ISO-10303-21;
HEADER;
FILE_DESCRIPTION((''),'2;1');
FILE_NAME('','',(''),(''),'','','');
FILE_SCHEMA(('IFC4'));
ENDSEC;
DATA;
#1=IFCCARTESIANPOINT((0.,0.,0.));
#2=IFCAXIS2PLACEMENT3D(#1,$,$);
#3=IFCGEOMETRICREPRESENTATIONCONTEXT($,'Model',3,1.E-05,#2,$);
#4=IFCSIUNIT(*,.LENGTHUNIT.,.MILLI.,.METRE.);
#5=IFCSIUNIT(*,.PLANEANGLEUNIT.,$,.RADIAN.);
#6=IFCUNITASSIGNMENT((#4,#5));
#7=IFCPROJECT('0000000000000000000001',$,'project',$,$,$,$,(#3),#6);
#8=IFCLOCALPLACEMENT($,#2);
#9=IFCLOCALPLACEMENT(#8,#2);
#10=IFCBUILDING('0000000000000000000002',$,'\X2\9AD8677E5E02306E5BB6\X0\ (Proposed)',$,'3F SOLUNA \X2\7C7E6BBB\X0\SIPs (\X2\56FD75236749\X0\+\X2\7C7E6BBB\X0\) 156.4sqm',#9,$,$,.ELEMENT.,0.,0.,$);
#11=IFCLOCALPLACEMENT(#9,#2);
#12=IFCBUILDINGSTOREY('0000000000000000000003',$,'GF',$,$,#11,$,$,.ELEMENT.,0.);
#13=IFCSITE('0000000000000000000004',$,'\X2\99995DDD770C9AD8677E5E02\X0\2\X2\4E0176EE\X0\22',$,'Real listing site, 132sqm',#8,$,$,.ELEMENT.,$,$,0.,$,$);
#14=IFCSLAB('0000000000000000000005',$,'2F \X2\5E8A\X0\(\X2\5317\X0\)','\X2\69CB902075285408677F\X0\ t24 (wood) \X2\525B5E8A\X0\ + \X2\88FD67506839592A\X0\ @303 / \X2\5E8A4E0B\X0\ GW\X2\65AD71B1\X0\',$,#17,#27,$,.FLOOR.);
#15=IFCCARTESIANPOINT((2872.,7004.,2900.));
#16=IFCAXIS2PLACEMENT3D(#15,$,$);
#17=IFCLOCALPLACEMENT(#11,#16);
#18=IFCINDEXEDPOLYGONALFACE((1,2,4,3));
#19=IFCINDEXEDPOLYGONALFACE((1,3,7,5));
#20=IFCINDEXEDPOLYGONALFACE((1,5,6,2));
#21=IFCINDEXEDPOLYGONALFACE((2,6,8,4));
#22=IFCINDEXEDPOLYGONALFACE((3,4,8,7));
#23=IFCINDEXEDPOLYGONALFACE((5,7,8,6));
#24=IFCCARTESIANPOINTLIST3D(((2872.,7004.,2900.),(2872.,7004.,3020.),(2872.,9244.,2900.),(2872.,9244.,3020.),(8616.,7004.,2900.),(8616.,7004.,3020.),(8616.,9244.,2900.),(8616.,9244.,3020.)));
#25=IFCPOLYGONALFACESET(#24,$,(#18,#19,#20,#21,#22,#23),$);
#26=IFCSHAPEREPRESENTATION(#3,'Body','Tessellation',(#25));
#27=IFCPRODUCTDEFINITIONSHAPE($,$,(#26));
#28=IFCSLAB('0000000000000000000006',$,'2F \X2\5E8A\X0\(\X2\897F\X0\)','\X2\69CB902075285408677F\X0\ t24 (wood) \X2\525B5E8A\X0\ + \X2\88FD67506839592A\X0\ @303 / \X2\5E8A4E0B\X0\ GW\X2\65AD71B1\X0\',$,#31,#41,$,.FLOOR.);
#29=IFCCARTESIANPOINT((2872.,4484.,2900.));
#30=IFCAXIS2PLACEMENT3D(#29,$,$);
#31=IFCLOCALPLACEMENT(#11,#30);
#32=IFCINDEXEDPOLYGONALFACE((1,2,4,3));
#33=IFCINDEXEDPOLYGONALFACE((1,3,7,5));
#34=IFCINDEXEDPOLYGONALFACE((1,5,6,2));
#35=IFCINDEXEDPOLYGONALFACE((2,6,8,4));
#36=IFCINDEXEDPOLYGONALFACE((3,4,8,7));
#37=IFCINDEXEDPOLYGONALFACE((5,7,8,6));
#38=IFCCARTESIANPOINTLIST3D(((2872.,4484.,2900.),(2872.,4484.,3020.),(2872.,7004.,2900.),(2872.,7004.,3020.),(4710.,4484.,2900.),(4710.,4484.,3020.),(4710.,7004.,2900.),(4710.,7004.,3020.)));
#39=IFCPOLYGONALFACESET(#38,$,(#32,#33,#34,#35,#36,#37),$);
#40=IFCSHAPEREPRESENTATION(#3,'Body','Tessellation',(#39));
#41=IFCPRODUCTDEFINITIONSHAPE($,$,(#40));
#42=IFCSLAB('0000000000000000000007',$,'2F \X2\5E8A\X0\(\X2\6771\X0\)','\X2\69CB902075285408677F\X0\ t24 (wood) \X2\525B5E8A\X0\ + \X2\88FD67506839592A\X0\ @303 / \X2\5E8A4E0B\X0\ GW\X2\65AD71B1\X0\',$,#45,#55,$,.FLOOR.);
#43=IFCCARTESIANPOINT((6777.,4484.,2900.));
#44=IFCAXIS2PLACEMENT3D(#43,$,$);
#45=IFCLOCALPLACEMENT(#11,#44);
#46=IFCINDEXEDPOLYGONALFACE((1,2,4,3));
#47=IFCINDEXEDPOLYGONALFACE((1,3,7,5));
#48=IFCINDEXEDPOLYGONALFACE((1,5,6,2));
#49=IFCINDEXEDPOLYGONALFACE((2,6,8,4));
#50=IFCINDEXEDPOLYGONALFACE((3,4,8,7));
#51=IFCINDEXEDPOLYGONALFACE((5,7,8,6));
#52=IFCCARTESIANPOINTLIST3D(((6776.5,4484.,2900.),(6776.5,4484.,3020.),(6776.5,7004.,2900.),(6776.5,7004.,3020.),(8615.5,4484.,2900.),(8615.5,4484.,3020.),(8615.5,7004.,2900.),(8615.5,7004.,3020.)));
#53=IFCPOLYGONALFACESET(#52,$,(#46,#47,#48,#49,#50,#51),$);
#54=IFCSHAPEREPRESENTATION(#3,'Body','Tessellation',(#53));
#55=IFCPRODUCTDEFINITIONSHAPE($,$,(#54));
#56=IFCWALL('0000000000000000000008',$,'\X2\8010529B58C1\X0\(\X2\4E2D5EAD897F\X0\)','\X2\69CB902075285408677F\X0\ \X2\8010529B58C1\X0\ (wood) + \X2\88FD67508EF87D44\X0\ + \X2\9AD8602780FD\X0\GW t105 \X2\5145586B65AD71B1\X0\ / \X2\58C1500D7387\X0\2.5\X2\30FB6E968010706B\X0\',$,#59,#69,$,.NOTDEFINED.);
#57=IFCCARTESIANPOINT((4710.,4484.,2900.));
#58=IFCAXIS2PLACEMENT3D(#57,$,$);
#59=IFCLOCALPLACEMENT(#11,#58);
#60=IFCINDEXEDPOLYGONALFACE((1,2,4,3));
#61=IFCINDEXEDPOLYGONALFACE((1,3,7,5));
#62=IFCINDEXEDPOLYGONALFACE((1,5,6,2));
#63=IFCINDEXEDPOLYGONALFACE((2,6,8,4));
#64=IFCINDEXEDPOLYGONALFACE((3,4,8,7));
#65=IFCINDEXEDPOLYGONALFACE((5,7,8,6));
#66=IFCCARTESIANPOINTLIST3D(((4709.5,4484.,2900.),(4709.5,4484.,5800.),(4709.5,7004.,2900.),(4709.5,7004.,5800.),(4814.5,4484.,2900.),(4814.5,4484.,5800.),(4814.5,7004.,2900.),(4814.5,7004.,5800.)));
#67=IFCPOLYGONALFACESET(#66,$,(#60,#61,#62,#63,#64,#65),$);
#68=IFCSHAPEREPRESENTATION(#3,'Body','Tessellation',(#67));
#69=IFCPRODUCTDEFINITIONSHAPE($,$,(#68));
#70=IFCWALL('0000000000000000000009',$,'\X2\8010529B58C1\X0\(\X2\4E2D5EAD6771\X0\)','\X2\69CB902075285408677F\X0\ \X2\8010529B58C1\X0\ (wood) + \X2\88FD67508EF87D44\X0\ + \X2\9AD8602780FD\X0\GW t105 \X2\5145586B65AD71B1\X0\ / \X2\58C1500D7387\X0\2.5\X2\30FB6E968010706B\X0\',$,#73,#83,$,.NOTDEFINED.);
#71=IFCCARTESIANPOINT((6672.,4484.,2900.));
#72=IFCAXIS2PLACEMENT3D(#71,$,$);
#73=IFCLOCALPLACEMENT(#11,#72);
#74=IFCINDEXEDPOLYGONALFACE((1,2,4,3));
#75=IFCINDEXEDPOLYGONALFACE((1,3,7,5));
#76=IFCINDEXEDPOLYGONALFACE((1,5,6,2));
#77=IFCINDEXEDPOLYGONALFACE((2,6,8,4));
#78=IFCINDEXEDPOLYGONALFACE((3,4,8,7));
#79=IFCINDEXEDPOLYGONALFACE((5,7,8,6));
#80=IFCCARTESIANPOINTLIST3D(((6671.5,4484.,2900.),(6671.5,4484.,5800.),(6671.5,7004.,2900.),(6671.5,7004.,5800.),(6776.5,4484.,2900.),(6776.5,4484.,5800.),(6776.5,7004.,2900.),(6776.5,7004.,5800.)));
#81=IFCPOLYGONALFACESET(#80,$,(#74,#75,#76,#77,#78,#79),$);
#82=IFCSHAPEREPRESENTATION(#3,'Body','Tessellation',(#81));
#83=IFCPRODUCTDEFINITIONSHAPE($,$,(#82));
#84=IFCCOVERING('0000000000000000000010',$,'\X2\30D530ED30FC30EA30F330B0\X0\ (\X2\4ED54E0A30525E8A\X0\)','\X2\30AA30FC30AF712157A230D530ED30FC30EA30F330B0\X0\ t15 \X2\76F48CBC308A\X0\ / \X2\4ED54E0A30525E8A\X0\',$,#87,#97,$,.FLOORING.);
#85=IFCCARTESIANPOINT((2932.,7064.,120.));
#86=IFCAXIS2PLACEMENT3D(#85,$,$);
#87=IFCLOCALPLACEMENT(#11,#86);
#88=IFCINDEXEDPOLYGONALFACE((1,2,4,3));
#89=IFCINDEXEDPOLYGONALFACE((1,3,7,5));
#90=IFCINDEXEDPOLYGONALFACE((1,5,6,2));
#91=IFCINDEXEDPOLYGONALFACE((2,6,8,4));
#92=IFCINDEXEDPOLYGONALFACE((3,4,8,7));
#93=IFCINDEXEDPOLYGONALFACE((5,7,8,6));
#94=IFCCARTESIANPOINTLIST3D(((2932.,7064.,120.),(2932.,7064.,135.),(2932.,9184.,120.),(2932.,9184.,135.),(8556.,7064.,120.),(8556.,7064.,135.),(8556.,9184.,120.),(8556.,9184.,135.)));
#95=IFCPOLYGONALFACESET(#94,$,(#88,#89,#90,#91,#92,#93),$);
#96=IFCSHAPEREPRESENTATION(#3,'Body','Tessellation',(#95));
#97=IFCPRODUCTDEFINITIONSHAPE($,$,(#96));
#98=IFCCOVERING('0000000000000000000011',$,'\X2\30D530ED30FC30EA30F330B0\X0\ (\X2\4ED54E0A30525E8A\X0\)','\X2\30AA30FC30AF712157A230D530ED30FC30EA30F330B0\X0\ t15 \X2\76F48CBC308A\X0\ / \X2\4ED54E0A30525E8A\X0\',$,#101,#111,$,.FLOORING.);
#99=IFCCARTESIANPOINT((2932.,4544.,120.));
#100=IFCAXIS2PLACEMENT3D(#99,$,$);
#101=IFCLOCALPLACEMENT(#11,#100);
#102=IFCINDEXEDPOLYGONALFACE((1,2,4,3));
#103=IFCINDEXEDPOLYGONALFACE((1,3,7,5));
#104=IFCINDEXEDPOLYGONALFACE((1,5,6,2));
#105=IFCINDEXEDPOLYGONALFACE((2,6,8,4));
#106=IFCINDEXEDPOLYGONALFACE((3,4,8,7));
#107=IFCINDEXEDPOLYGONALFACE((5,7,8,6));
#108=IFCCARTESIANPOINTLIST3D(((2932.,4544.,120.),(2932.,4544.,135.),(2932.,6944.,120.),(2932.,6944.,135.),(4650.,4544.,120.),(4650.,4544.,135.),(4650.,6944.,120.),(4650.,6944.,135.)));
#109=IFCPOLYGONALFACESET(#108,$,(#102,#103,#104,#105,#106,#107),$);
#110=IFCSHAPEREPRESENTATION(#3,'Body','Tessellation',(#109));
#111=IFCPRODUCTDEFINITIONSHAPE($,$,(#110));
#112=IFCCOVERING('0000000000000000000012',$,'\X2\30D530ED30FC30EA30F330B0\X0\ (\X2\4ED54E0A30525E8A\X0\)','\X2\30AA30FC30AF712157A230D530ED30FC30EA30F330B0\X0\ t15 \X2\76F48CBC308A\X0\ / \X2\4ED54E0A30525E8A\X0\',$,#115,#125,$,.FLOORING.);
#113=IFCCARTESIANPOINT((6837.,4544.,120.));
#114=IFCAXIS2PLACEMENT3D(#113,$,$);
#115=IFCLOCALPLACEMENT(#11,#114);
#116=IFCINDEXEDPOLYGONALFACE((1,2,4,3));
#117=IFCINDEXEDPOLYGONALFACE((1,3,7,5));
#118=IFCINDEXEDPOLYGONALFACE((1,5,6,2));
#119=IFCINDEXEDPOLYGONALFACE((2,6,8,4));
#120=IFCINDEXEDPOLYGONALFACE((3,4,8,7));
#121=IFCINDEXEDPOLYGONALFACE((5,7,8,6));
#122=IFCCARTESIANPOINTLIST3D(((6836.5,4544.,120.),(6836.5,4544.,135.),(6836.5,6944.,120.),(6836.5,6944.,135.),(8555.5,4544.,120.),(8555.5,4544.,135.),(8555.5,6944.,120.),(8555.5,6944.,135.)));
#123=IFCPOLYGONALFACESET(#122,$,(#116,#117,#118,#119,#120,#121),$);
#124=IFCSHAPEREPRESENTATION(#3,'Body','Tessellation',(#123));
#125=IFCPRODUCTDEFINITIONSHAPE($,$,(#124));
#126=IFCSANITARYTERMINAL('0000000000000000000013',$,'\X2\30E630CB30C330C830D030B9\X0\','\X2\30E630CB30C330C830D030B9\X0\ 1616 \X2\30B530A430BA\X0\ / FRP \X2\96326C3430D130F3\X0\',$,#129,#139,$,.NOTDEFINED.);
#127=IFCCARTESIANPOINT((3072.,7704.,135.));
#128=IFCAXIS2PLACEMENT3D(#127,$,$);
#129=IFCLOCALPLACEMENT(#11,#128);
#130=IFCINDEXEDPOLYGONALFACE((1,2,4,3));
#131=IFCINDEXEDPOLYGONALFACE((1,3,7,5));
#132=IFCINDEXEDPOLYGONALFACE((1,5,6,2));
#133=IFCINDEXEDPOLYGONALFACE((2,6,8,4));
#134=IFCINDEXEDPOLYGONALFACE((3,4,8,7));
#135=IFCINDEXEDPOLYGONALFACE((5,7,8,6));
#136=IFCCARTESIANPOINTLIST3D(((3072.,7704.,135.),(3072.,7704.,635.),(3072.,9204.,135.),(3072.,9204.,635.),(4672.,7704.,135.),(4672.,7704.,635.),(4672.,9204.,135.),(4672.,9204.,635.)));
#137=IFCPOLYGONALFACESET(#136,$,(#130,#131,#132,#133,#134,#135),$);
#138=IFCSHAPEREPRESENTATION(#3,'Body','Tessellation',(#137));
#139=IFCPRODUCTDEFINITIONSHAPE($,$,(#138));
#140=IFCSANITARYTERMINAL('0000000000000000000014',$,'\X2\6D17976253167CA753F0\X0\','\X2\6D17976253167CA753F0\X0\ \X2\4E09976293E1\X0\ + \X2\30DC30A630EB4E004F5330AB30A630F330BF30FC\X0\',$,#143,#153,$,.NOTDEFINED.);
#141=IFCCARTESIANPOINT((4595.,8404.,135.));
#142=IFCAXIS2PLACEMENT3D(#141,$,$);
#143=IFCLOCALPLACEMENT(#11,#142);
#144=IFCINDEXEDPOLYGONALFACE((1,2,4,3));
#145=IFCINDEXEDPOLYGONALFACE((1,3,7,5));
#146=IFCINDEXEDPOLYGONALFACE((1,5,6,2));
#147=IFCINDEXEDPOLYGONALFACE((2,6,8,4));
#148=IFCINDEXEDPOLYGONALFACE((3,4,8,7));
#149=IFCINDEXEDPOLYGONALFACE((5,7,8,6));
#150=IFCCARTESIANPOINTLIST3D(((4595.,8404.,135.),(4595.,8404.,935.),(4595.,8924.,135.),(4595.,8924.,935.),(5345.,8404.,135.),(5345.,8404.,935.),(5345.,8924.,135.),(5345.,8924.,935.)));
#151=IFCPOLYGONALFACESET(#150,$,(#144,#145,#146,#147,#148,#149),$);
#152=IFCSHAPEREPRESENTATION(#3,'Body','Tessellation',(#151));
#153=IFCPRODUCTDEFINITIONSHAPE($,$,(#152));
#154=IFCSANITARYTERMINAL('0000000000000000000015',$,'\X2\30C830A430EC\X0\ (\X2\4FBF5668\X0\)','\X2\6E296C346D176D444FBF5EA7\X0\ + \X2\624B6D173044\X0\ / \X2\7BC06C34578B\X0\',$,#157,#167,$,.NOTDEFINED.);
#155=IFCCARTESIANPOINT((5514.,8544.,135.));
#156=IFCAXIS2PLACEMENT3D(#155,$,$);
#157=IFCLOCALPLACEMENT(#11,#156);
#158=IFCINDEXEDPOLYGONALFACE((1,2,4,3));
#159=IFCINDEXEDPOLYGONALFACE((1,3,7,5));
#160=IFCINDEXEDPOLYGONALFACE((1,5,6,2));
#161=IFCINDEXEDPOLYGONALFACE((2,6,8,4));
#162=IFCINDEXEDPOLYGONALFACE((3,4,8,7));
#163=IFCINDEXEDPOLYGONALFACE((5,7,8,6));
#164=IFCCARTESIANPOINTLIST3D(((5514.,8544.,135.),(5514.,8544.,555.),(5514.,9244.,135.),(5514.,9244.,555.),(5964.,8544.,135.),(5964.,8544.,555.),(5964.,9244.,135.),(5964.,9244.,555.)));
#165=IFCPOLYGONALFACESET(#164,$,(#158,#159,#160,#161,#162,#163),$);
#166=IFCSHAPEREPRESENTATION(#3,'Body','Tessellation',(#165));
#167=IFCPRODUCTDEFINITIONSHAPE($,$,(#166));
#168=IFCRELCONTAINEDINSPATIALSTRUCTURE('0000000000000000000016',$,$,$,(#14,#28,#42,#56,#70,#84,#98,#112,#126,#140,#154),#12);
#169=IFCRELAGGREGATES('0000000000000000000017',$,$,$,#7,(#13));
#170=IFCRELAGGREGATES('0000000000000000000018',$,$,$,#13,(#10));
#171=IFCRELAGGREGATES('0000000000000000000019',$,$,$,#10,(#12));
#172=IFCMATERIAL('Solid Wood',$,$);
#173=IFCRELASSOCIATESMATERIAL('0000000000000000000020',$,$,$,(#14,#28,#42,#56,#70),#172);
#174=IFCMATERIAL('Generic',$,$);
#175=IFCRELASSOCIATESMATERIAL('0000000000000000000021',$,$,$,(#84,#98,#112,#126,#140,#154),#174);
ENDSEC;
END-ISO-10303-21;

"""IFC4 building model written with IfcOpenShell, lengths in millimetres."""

from ifc_helpers import new_model, si_unit, frame, frame_2d, origin, place, context, project, spatial, rectangle, extrude, material, element, save


model = new_model("IFC4")

# Units and contexts
model_context = context("Model", 3, precision=1e-05, world=origin())
ifc_project = project(units=[si_unit("LENGTHUNIT", "METRE", prefix="MILLI"), si_unit("PLANEANGLEUNIT", "RADIAN")], contexts=[model_context])

# Site, building, storey
site_placement = place(None, origin())
site = spatial("IfcSite", under=ifc_project, at=site_placement, Name="香川県高松市2丁目22", ObjectType="Real listing site, 132sqm", CompositionType="ELEMENT", RefElevation=0.0)
building_placement = place(site_placement, origin())
building = spatial("IfcBuilding", under=site, at=building_placement, Name="高松市の家 (Proposed)", ObjectType="3F SOLUNA 籾殻SIPs (国産杉+籾殻) 156.4sqm", CompositionType="ELEMENT", ElevationOfRefHeight=0.0, ElevationOfTerrain=0.0)
storey_placement = place(building_placement, origin())
storey = spatial("IfcBuildingStorey", under=building, at=storey_placement, Name="GF", CompositionType="ELEMENT", Elevation=0.0)

# Slabs
ifc_material_1 = material(Name="Solid Wood")
slab_1_placement = place(storey_placement, frame((2872.0, 7004.0, 2900.0)))
element("IfcSlab", 1, at=slab_1_placement, inside=storey, material=ifc_material_1, Name="2F 床(北)", Description="構造用合板 t24 (wood) 剛床 + 製材根太 @303 / 床下 GW断熱", PredefinedType="FLOOR", context=model_context, shape_type="SweptSolid", body=[
    extrude(rectangle(XDim=5744.0, YDim=2240.0, at=frame_2d((2872.0, 1120.0))), frame((2872.0, 7004.0, 2900.0)), (0.0, 0.0, 1.0), 120.0),
])
slab_2_placement = place(storey_placement, frame((2872.0, 4484.0, 2900.0)))
element("IfcSlab", 2, at=slab_2_placement, inside=storey, material=ifc_material_1, Name="2F 床(西)", Description="構造用合板 t24 (wood) 剛床 + 製材根太 @303 / 床下 GW断熱", PredefinedType="FLOOR", context=model_context, shape_type="SweptSolid", body=[
    extrude(rectangle(XDim=1838.0, YDim=2520.0, at=frame_2d((919.0, 1260.0))), frame((2872.0, 4484.0, 2900.0)), (0.0, 0.0, 1.0), 120.0),
])
slab_3_placement = place(storey_placement, frame((6777.0, 4484.0, 2900.0)))
element("IfcSlab", 3, at=slab_3_placement, inside=storey, material=ifc_material_1, Name="2F 床(東)", Description="構造用合板 t24 (wood) 剛床 + 製材根太 @303 / 床下 GW断熱", PredefinedType="FLOOR", context=model_context, shape_type="SweptSolid", body=[
    extrude(rectangle(XDim=1839.0, YDim=2520.0, at=frame_2d((919.0, 1260.0))), frame((6777.0, 4484.0, 2900.0)), (0.0, 0.0, 1.0), 120.0),
])

# Walls
wall_1_placement = place(storey_placement, frame((4710.0, 4484.0, 2900.0)))
element("IfcWall", 4, at=wall_1_placement, inside=storey, material=ifc_material_1, Name="耐力壁(中庭西)", Description="構造用合板 耐力壁 (wood) + 製材軸組 + 高性能GW t105 充填断熱 / 壁倍率2.5・準耐火", PredefinedType="NOTDEFINED", context=model_context, shape_type="SweptSolid", body=[
    extrude(rectangle(XDim=105.0, YDim=2520.0, at=frame_2d((52.0, 1260.0))), frame((4710.0, 4484.0, 2900.0)), (0.0, 0.0, 1.0), 2900.0),
])
wall_2_placement = place(storey_placement, frame((6672.0, 4484.0, 2900.0)))
element("IfcWall", 5, at=wall_2_placement, inside=storey, material=ifc_material_1, Name="耐力壁(中庭東)", Description="構造用合板 耐力壁 (wood) + 製材軸組 + 高性能GW t105 充填断熱 / 壁倍率2.5・準耐火", PredefinedType="NOTDEFINED", context=model_context, shape_type="SweptSolid", body=[
    extrude(rectangle(XDim=105.0, YDim=2520.0, at=frame_2d((52.0, 1260.0))), frame((6672.0, 4484.0, 2900.0)), (0.0, 0.0, 1.0), 2900.0),
])

# Coverings
ifc_material_2 = material(Name="Generic")
covering_1_placement = place(storey_placement, frame((2932.0, 7064.0, 120.0)))
element("IfcCovering", 6, at=covering_1_placement, inside=storey, material=ifc_material_2, Name="フローリング (仕上げ床)", Description="オーク無垢フローリング t15 直貼り / 仕上げ床", PredefinedType="FLOORING", context=model_context, shape_type="SweptSolid", body=[
    extrude(rectangle(XDim=5624.0, YDim=2120.0, at=frame_2d((2812.0, 1060.0))), frame((2932.0, 7064.0, 120.0)), (0.0, 0.0, 1.0), 15.0),
])
covering_2_placement = place(storey_placement, frame((2932.0, 4544.0, 120.0)))
element("IfcCovering", 7, at=covering_2_placement, inside=storey, material=ifc_material_2, Name="フローリング (仕上げ床)", Description="オーク無垢フローリング t15 直貼り / 仕上げ床", PredefinedType="FLOORING", context=model_context, shape_type="SweptSolid", body=[
    extrude(rectangle(XDim=1718.0, YDim=2400.0, at=frame_2d((859.0, 1200.0))), frame((2932.0, 4544.0, 120.0)), (0.0, 0.0, 1.0), 15.0),
])
covering_3_placement = place(storey_placement, frame((6837.0, 4544.0, 120.0)))
element("IfcCovering", 8, at=covering_3_placement, inside=storey, material=ifc_material_2, Name="フローリング (仕上げ床)", Description="オーク無垢フローリング t15 直貼り / 仕上げ床", PredefinedType="FLOORING", context=model_context, shape_type="SweptSolid", body=[
    extrude(rectangle(XDim=1719.0, YDim=2400.0, at=frame_2d((859.0, 1200.0))), frame((6837.0, 4544.0, 120.0)), (0.0, 0.0, 1.0), 15.0),
])

# Sanitary terminals
sanitary_terminal_1_placement = place(storey_placement, frame((3072.0, 7704.0, 135.0)))
element("IfcSanitaryTerminal", 9, at=sanitary_terminal_1_placement, inside=storey, material=ifc_material_2, Name="ユニットバス", Description="ユニットバス 1616 サイズ / FRP 防水パン", PredefinedType="NOTDEFINED", context=model_context, shape_type="SweptSolid", body=[
    extrude(rectangle(XDim=1600.0, YDim=1500.0, at=frame_2d((800.0, 750.0))), frame((3072.0, 7704.0, 135.0)), (0.0, 0.0, 1.0), 500.0),
])
sanitary_terminal_2_placement = place(storey_placement, frame((4595.0, 8404.0, 135.0)))
element("IfcSanitaryTerminal", 10, at=sanitary_terminal_2_placement, inside=storey, material=ifc_material_2, Name="洗面化粧台", Description="洗面化粧台 三面鏡 + ボウル一体カウンター", PredefinedType="NOTDEFINED", context=model_context, shape_type="SweptSolid", body=[
    extrude(rectangle(XDim=750.0, YDim=520.0, at=frame_2d((375.0, 260.0))), frame((4595.0, 8404.0, 135.0)), (0.0, 0.0, 1.0), 800.0),
])
sanitary_terminal_3_placement = place(storey_placement, frame((5514.0, 8544.0, 135.0)))
element("IfcSanitaryTerminal", 11, at=sanitary_terminal_3_placement, inside=storey, material=ifc_material_2, Name="トイレ (便器)", Description="温水洗浄便座 + 手洗い / 節水型", PredefinedType="NOTDEFINED", context=model_context, shape_type="SweptSolid", body=[
    extrude(rectangle(XDim=450.0, YDim=700.0, at=frame_2d((225.0, 350.0))), frame((5514.0, 8544.0, 135.0)), (0.0, 0.0, 1.0), 420.0),
])

save(model, "model.ifc")
